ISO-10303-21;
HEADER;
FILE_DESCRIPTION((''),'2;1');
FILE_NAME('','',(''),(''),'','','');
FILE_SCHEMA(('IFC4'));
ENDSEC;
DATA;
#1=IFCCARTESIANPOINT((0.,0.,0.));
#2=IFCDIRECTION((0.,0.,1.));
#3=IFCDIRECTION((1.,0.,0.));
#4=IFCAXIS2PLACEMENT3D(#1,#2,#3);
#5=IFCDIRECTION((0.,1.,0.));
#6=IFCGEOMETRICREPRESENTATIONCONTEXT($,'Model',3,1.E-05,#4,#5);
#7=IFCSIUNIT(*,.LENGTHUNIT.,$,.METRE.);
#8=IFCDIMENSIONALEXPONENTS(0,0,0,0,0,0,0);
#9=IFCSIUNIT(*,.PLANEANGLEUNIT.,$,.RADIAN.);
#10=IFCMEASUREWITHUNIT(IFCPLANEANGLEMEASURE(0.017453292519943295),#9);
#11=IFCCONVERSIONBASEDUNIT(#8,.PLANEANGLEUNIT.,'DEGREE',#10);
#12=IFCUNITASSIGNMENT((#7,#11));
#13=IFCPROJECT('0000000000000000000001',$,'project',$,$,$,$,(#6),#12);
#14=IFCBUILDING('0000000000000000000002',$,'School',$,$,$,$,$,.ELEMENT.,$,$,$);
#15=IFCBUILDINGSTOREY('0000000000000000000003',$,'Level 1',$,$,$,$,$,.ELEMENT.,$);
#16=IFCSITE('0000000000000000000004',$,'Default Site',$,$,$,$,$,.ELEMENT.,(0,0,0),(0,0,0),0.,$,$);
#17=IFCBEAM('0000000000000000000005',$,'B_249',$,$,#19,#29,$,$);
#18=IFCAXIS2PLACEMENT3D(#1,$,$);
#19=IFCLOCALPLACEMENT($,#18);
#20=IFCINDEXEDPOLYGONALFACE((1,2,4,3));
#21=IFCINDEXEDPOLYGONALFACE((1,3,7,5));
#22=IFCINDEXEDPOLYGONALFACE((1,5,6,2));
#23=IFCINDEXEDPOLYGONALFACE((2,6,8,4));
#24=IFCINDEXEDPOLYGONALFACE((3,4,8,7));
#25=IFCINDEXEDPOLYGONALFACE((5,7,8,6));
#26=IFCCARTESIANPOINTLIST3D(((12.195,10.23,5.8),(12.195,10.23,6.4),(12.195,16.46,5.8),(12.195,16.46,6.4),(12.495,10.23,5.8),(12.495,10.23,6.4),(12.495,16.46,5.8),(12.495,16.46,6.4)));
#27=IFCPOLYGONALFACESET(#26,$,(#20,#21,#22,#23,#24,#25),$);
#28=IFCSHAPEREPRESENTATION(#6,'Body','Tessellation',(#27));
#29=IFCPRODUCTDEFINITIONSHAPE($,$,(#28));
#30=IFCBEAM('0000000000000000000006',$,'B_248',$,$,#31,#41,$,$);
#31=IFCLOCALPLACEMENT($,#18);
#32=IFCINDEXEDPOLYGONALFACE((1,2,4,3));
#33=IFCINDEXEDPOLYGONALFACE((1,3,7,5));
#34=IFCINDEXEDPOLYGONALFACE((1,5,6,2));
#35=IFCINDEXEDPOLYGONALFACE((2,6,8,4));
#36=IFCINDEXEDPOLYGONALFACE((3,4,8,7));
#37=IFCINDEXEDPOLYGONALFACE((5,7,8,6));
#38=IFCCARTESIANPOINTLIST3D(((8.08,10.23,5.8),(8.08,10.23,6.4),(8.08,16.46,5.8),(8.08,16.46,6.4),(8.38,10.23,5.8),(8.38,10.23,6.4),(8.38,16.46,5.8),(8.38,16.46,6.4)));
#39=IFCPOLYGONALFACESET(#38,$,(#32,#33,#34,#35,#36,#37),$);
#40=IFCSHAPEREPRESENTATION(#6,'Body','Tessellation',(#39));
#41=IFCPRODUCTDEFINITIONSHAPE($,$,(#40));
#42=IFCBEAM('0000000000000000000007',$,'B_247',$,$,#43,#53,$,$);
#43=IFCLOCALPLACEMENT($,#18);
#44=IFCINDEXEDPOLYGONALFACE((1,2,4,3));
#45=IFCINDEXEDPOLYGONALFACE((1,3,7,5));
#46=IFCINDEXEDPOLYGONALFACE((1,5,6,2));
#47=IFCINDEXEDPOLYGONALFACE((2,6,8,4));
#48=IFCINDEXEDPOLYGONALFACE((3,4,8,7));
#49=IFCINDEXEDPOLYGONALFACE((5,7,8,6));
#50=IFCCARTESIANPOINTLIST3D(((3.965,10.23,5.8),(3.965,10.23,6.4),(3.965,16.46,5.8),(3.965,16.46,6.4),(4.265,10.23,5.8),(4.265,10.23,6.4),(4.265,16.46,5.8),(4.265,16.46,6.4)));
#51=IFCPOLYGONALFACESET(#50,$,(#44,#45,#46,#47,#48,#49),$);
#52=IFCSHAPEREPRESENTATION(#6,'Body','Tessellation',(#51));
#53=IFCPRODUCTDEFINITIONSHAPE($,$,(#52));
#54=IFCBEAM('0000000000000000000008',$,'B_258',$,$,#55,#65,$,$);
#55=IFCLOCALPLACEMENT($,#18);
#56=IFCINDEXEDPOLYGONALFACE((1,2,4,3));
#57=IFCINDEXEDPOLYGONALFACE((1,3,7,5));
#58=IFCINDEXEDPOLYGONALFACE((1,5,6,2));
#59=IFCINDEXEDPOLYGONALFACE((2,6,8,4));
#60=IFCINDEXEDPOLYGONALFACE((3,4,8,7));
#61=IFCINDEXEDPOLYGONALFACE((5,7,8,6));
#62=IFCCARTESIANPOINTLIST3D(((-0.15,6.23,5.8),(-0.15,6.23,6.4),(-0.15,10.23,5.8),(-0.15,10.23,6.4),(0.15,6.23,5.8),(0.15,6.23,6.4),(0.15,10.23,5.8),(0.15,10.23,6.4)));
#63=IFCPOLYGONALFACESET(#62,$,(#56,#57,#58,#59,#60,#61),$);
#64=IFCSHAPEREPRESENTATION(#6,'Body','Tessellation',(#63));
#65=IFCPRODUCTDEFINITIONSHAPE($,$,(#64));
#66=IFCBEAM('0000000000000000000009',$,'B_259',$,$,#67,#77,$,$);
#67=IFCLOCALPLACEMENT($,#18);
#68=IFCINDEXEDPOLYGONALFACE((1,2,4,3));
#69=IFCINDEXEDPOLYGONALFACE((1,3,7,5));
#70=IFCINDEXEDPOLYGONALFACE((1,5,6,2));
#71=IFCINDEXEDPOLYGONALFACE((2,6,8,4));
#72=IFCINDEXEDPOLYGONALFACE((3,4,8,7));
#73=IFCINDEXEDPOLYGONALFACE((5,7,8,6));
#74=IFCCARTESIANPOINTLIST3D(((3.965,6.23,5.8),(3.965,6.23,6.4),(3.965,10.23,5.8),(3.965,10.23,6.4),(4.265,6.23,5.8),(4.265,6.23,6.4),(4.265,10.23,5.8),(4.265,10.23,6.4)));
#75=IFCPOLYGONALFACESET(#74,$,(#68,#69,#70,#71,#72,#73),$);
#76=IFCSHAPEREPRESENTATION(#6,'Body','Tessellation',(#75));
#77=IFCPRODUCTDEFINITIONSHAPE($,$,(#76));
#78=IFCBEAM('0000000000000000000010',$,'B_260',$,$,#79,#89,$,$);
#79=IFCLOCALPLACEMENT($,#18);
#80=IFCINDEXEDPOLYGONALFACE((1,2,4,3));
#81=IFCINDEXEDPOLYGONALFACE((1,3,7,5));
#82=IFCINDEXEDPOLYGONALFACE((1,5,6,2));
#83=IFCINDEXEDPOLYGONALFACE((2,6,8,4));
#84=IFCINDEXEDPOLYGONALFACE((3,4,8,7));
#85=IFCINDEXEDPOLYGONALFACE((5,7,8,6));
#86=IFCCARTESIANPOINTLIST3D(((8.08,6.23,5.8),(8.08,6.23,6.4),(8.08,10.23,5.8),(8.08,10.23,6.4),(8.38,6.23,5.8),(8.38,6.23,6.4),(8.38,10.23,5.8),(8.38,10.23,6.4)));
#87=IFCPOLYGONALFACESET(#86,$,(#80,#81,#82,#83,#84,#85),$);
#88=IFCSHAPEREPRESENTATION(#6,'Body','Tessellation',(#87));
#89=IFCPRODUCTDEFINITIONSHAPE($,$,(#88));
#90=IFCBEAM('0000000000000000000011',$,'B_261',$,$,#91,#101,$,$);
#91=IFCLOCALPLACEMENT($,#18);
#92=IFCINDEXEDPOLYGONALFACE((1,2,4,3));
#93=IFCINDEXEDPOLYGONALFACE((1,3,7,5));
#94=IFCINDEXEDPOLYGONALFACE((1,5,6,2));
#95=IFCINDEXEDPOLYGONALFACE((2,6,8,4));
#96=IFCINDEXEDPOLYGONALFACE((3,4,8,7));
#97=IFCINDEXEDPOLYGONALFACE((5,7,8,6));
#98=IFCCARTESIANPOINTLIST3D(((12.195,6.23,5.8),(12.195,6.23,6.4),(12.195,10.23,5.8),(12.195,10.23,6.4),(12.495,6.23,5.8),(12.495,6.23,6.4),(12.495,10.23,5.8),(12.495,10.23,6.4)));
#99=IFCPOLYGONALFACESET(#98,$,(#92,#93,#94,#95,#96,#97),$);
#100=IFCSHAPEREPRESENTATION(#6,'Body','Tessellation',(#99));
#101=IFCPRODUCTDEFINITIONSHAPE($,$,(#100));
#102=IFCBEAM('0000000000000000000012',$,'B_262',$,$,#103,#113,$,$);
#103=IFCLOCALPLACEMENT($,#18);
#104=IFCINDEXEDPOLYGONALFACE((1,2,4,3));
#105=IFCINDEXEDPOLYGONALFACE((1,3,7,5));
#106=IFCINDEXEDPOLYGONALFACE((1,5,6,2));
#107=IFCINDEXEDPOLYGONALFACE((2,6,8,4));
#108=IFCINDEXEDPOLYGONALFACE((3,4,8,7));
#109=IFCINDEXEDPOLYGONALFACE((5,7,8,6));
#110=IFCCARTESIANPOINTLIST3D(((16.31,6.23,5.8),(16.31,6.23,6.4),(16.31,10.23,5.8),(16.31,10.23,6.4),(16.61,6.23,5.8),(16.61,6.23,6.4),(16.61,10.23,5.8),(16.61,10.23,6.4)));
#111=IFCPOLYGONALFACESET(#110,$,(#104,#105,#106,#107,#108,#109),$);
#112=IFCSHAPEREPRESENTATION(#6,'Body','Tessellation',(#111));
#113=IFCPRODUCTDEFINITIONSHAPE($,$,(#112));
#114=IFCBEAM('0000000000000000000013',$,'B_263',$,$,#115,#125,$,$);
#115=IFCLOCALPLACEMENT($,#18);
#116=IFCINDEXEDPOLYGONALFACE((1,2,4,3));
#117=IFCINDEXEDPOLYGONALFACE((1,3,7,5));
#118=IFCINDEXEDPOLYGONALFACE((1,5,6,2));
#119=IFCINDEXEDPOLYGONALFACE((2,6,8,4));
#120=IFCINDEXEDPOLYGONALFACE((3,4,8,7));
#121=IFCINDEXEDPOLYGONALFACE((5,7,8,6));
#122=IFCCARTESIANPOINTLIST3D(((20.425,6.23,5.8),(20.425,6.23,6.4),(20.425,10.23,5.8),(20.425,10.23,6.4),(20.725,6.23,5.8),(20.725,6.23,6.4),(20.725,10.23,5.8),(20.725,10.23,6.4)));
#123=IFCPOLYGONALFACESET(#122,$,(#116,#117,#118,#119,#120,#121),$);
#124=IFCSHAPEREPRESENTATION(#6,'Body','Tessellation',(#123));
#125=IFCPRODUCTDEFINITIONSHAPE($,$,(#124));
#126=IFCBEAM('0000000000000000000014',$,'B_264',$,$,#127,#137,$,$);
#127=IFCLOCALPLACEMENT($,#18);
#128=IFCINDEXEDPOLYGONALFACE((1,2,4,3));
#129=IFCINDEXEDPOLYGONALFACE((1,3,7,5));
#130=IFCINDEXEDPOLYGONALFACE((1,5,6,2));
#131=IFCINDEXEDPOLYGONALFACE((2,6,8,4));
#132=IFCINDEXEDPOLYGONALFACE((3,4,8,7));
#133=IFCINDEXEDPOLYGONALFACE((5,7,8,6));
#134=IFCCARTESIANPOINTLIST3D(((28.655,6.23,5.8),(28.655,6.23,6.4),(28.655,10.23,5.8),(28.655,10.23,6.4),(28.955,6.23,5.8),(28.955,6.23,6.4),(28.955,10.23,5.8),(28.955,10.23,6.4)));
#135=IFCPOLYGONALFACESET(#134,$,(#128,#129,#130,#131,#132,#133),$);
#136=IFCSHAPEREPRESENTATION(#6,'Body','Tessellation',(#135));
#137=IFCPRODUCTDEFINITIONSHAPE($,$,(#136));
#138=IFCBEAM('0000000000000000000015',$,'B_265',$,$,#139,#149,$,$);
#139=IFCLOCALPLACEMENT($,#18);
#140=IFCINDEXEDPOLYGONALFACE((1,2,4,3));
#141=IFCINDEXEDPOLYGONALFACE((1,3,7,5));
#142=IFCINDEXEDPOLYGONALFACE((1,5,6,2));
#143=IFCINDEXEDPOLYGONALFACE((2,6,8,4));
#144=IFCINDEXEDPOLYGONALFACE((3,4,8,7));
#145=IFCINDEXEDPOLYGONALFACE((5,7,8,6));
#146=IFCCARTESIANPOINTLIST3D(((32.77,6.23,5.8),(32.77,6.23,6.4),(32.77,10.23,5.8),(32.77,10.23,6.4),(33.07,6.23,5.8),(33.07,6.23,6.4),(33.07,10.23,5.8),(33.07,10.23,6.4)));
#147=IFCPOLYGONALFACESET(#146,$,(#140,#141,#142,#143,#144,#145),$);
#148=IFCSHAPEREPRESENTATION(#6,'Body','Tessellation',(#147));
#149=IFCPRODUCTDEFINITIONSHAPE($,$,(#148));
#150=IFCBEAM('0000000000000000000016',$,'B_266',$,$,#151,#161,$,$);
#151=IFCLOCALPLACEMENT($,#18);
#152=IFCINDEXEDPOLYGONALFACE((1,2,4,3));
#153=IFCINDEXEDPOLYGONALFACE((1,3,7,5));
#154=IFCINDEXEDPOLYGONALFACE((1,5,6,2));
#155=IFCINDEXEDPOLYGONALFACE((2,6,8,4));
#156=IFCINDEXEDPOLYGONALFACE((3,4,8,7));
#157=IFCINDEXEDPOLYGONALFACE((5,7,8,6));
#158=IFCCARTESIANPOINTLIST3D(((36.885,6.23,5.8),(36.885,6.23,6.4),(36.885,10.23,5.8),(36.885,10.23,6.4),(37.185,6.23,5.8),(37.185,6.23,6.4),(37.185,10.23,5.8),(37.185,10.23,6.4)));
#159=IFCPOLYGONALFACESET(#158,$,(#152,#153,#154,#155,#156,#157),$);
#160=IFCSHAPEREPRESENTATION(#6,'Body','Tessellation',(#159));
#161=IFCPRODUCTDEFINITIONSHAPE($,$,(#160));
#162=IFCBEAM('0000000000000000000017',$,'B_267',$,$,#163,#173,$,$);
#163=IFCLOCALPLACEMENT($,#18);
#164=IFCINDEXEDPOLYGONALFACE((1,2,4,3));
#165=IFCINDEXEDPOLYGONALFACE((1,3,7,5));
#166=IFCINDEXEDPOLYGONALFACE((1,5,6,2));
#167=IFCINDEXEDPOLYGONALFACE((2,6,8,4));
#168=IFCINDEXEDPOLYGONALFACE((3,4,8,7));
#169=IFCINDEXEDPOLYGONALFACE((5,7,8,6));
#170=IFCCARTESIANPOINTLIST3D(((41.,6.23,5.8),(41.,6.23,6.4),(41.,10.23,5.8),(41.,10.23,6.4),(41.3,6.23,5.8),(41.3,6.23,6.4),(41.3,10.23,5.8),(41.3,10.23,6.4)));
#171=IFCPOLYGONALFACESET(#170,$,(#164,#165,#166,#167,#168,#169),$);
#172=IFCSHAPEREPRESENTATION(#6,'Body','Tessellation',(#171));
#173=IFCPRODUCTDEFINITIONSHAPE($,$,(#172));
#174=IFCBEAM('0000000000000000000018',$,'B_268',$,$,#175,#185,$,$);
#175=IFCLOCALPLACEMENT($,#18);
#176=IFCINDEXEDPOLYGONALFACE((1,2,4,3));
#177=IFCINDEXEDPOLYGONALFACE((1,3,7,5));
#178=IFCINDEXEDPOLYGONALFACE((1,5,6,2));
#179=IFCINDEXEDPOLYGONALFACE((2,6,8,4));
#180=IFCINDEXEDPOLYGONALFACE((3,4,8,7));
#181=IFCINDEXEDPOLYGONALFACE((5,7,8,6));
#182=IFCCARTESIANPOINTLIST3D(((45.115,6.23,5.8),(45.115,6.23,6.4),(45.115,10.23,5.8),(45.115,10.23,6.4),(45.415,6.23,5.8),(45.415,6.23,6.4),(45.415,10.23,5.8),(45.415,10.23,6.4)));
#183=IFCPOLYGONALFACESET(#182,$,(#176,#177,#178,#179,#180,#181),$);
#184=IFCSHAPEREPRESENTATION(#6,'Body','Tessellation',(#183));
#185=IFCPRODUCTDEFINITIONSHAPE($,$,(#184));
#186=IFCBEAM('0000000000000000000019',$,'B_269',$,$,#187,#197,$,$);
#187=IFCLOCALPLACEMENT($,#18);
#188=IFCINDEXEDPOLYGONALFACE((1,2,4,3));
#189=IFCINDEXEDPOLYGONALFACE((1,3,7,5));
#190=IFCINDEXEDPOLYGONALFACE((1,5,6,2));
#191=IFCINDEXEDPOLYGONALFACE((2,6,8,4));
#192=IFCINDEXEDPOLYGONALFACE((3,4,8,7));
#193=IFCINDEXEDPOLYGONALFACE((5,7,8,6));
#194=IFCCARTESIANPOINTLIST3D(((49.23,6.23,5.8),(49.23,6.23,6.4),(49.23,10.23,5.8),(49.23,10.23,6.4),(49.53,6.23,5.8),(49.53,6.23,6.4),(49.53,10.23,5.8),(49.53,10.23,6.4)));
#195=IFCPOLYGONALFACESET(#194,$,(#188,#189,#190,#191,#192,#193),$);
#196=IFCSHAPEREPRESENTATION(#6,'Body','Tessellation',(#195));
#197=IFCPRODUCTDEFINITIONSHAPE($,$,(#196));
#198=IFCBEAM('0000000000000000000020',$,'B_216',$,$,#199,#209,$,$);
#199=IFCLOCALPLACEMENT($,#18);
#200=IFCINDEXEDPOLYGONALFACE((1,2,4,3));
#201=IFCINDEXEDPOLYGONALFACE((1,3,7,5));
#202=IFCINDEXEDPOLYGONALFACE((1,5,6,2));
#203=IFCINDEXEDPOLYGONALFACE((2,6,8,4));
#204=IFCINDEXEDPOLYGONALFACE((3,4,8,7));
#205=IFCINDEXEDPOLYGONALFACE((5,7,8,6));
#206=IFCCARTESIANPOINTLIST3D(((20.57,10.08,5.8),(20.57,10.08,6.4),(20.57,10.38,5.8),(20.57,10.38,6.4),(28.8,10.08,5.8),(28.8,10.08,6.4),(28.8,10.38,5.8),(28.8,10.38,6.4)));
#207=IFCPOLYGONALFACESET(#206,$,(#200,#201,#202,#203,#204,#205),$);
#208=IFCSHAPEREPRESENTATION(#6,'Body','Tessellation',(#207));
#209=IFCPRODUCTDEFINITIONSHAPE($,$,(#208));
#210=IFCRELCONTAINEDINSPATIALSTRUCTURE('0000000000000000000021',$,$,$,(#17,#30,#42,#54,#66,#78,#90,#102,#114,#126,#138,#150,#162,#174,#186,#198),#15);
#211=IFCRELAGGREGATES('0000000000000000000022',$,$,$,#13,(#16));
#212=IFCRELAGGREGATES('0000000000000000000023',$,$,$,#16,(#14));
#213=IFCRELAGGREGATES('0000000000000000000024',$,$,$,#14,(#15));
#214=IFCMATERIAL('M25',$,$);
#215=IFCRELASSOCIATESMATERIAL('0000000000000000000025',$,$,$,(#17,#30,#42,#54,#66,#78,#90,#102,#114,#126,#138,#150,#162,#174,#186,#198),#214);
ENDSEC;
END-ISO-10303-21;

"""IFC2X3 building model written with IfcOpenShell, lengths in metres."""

from ifc_helpers import new_model, entity, si_unit, converted_unit, direction, frame, frame_2d, origin_with_axes, place, context, project, spatial, rectangle, extrude, material, element, save


model = new_model("IFC2X3")

# Units and contexts
model_context = context("Model", 3, precision=1e-05, world=origin_with_axes(), true_north=direction((0.0, 1.0, 0.0)))
ifc_project = project(units=[si_unit("LENGTHUNIT", "METRE"), converted_unit("PLANEANGLEUNIT", "DEGREE", entity("IfcPlaneAngleMeasure", 0.017453292519943295), si_unit("PLANEANGLEUNIT", "RADIAN"), dimensions=[0, 0, 0, 0, 0, 0, 0])], contexts=[model_context])

# Site, building, storey
site = spatial("IfcSite", under=ifc_project, Name="Default Site", CompositionType="ELEMENT", RefLatitude=(0, 0, 0), RefLongitude=(0, 0, 0), RefElevation=0.0)
building = spatial("IfcBuilding", under=site, Name="School", CompositionType="ELEMENT")
storey = spatial("IfcBuildingStorey", under=building, Name="Level 1", CompositionType="ELEMENT")

# Beams
ifc_material = material(Name="M25")
placement = place(None, origin_with_axes())
element("IfcBeam", 1, at=placement, inside=storey, material=ifc_material, Name="B_249", context=model_context, shape_type="SweptSolid", body=[
    extrude(rectangle(XDim=0.3, YDim=0.6, at=frame_2d((0.0, 0.0), x_axis=(0.0, 1.0, 0.0))), frame((12.345, 10.23, 6.1), z_axis=(0.0, 1.0, 0.0), x_axis=(0.0, 0.0, -1.0)), (0.0, 0.0, 1.0), 6.23),
])
element("IfcBeam", 2, at=placement, inside=storey, material=ifc_material, Name="B_248", context=model_context, shape_type="SweptSolid", body=[
    extrude(rectangle(XDim=0.3, YDim=0.6, at=frame_2d((0.0, 0.0), x_axis=(0.0, 1.0, 0.0))), frame((8.23, 10.23, 6.1), z_axis=(0.0, 1.0, 0.0), x_axis=(0.0, 0.0, -1.0)), (0.0, 0.0, 1.0), 6.23),
])
element("IfcBeam", 3, at=placement, inside=storey, material=ifc_material, Name="B_247", context=model_context, shape_type="SweptSolid", body=[
    extrude(rectangle(XDim=0.3, YDim=0.6, at=frame_2d((0.0, 0.0), x_axis=(0.0, 1.0, 0.0))), frame((4.115, 10.23, 6.1), z_axis=(0.0, 1.0, 0.0), x_axis=(0.0, 0.0, -1.0)), (0.0, 0.0, 1.0), 6.23),
])
element("IfcBeam", 4, at=placement, inside=storey, material=ifc_material, Name="B_258", context=model_context, shape_type="SweptSolid", body=[
    extrude(rectangle(XDim=0.3, YDim=0.6, at=frame_2d((0.0, 0.0), x_axis=(0.0, 1.0, 0.0))), frame((0.0, 6.23, 6.1), z_axis=(0.0, 1.0, 0.0), x_axis=(0.0, 0.0, -1.0)), (0.0, 0.0, 1.0), 4.0),
])
element("IfcBeam", 5, at=placement, inside=storey, material=ifc_material, Name="B_259", context=model_context, shape_type="SweptSolid", body=[
    extrude(rectangle(XDim=0.3, YDim=0.6, at=frame_2d((0.0, 0.0), x_axis=(0.0, 1.0, 0.0))), frame((4.115, 6.23, 6.1), z_axis=(0.0, 1.0, 0.0), x_axis=(0.0, 0.0, -1.0)), (0.0, 0.0, 1.0), 4.0),
])
element("IfcBeam", 6, at=placement, inside=storey, material=ifc_material, Name="B_260", context=model_context, shape_type="SweptSolid", body=[
    extrude(rectangle(XDim=0.3, YDim=0.6, at=frame_2d((0.0, 0.0), x_axis=(0.0, 1.0, 0.0))), frame((8.23, 6.23, 6.1), z_axis=(0.0, 1.0, 0.0), x_axis=(0.0, 0.0, -1.0)), (0.0, 0.0, 1.0), 4.0),
])
element("IfcBeam", 7, at=placement, inside=storey, material=ifc_material, Name="B_261", context=model_context, shape_type="SweptSolid", body=[
    extrude(rectangle(XDim=0.3, YDim=0.6, at=frame_2d((0.0, 0.0), x_axis=(0.0, 1.0, 0.0))), frame((12.345, 6.23, 6.1), z_axis=(0.0, 1.0, 0.0), x_axis=(0.0, 0.0, -1.0)), (0.0, 0.0, 1.0), 4.0),
])
element("IfcBeam", 8, at=placement, inside=storey, material=ifc_material, Name="B_262", context=model_context, shape_type="SweptSolid", body=[
    extrude(rectangle(XDim=0.3, YDim=0.6, at=frame_2d((0.0, 0.0), x_axis=(0.0, 1.0, 0.0))), frame((16.46, 6.23, 6.1), z_axis=(0.0, 1.0, 0.0), x_axis=(0.0, 0.0, -1.0)), (0.0, 0.0, 1.0), 4.0),
])
element("IfcBeam", 9, at=placement, inside=storey, material=ifc_material, Name="B_263", context=model_context, shape_type="SweptSolid", body=[
    extrude(rectangle(XDim=0.3, YDim=0.6, at=frame_2d((0.0, 0.0), x_axis=(0.0, 1.0, 0.0))), frame((20.575, 6.23, 6.1), z_axis=(0.0, 1.0, 0.0), x_axis=(0.0, 0.0, -1.0)), (0.0, 0.0, 1.0), 4.0),
])
element("IfcBeam", 10, at=placement, inside=storey, material=ifc_material, Name="B_264", context=model_context, shape_type="SweptSolid", body=[
    extrude(rectangle(XDim=0.3, YDim=0.6, at=frame_2d((0.0, 0.0), x_axis=(0.0, 1.0, 0.0))), frame((28.805, 6.23, 6.1), z_axis=(0.0, 1.0, 0.0), x_axis=(0.0, 0.0, -1.0)), (0.0, 0.0, 1.0), 4.0),
])
element("IfcBeam", 11, at=placement, inside=storey, material=ifc_material, Name="B_265", context=model_context, shape_type="SweptSolid", body=[
    extrude(rectangle(XDim=0.3, YDim=0.6, at=frame_2d((0.0, 0.0), x_axis=(0.0, 1.0, 0.0))), frame((32.92, 6.23, 6.1), z_axis=(0.0, 1.0, 0.0), x_axis=(0.0, 0.0, -1.0)), (0.0, 0.0, 1.0), 4.0),
])
element("IfcBeam", 12, at=placement, inside=storey, material=ifc_material, Name="B_266", context=model_context, shape_type="SweptSolid", body=[
    extrude(rectangle(XDim=0.3, YDim=0.6, at=frame_2d((0.0, 0.0), x_axis=(0.0, 1.0, 0.0))), frame((37.035, 6.23, 6.1), z_axis=(0.0, 1.0, 0.0), x_axis=(0.0, 0.0, -1.0)), (0.0, 0.0, 1.0), 4.0),
])
element("IfcBeam", 13, at=placement, inside=storey, material=ifc_material, Name="B_267", context=model_context, shape_type="SweptSolid", body=[
    extrude(rectangle(XDim=0.3, YDim=0.6, at=frame_2d((0.0, 0.0), x_axis=(0.0, 1.0, 0.0))), frame((41.15, 6.23, 6.1), z_axis=(0.0, 1.0, 0.0), x_axis=(0.0, 0.0, -1.0)), (0.0, 0.0, 1.0), 4.0),
])
element("IfcBeam", 14, at=placement, inside=storey, material=ifc_material, Name="B_268", context=model_context, shape_type="SweptSolid", body=[
    extrude(rectangle(XDim=0.3, YDim=0.6, at=frame_2d((0.0, 0.0), x_axis=(0.0, 1.0, 0.0))), frame((45.265, 6.23, 6.1), z_axis=(0.0, 1.0, 0.0), x_axis=(0.0, 0.0, -1.0)), (0.0, 0.0, 1.0), 4.0),
])
element("IfcBeam", 15, at=placement, inside=storey, material=ifc_material, Name="B_269", context=model_context, shape_type="SweptSolid", body=[
    extrude(rectangle(XDim=0.3, YDim=0.6, at=frame_2d((0.0, 0.0), x_axis=(0.0, 1.0, 0.0))), frame((49.38, 6.23, 6.1), z_axis=(0.0, 1.0, 0.0), x_axis=(0.0, 0.0, -1.0)), (0.0, 0.0, 1.0), 4.0),
])
element("IfcBeam", 16, at=placement, inside=storey, material=ifc_material, Name="B_216", context=model_context, shape_type="SweptSolid", body=[
    extrude(rectangle(XDim=0.3, YDim=0.6, at=frame_2d((0.0, 0.0), x_axis=(0.0, 1.0, 0.0))), frame((20.57, 10.23, 6.1), z_axis=(1.0, 0.0, 0.0), x_axis=(0.0, 0.0, -1.0)), (0.0, 0.0, 1.0), 8.23),
])

save(model, "model.ifc")
